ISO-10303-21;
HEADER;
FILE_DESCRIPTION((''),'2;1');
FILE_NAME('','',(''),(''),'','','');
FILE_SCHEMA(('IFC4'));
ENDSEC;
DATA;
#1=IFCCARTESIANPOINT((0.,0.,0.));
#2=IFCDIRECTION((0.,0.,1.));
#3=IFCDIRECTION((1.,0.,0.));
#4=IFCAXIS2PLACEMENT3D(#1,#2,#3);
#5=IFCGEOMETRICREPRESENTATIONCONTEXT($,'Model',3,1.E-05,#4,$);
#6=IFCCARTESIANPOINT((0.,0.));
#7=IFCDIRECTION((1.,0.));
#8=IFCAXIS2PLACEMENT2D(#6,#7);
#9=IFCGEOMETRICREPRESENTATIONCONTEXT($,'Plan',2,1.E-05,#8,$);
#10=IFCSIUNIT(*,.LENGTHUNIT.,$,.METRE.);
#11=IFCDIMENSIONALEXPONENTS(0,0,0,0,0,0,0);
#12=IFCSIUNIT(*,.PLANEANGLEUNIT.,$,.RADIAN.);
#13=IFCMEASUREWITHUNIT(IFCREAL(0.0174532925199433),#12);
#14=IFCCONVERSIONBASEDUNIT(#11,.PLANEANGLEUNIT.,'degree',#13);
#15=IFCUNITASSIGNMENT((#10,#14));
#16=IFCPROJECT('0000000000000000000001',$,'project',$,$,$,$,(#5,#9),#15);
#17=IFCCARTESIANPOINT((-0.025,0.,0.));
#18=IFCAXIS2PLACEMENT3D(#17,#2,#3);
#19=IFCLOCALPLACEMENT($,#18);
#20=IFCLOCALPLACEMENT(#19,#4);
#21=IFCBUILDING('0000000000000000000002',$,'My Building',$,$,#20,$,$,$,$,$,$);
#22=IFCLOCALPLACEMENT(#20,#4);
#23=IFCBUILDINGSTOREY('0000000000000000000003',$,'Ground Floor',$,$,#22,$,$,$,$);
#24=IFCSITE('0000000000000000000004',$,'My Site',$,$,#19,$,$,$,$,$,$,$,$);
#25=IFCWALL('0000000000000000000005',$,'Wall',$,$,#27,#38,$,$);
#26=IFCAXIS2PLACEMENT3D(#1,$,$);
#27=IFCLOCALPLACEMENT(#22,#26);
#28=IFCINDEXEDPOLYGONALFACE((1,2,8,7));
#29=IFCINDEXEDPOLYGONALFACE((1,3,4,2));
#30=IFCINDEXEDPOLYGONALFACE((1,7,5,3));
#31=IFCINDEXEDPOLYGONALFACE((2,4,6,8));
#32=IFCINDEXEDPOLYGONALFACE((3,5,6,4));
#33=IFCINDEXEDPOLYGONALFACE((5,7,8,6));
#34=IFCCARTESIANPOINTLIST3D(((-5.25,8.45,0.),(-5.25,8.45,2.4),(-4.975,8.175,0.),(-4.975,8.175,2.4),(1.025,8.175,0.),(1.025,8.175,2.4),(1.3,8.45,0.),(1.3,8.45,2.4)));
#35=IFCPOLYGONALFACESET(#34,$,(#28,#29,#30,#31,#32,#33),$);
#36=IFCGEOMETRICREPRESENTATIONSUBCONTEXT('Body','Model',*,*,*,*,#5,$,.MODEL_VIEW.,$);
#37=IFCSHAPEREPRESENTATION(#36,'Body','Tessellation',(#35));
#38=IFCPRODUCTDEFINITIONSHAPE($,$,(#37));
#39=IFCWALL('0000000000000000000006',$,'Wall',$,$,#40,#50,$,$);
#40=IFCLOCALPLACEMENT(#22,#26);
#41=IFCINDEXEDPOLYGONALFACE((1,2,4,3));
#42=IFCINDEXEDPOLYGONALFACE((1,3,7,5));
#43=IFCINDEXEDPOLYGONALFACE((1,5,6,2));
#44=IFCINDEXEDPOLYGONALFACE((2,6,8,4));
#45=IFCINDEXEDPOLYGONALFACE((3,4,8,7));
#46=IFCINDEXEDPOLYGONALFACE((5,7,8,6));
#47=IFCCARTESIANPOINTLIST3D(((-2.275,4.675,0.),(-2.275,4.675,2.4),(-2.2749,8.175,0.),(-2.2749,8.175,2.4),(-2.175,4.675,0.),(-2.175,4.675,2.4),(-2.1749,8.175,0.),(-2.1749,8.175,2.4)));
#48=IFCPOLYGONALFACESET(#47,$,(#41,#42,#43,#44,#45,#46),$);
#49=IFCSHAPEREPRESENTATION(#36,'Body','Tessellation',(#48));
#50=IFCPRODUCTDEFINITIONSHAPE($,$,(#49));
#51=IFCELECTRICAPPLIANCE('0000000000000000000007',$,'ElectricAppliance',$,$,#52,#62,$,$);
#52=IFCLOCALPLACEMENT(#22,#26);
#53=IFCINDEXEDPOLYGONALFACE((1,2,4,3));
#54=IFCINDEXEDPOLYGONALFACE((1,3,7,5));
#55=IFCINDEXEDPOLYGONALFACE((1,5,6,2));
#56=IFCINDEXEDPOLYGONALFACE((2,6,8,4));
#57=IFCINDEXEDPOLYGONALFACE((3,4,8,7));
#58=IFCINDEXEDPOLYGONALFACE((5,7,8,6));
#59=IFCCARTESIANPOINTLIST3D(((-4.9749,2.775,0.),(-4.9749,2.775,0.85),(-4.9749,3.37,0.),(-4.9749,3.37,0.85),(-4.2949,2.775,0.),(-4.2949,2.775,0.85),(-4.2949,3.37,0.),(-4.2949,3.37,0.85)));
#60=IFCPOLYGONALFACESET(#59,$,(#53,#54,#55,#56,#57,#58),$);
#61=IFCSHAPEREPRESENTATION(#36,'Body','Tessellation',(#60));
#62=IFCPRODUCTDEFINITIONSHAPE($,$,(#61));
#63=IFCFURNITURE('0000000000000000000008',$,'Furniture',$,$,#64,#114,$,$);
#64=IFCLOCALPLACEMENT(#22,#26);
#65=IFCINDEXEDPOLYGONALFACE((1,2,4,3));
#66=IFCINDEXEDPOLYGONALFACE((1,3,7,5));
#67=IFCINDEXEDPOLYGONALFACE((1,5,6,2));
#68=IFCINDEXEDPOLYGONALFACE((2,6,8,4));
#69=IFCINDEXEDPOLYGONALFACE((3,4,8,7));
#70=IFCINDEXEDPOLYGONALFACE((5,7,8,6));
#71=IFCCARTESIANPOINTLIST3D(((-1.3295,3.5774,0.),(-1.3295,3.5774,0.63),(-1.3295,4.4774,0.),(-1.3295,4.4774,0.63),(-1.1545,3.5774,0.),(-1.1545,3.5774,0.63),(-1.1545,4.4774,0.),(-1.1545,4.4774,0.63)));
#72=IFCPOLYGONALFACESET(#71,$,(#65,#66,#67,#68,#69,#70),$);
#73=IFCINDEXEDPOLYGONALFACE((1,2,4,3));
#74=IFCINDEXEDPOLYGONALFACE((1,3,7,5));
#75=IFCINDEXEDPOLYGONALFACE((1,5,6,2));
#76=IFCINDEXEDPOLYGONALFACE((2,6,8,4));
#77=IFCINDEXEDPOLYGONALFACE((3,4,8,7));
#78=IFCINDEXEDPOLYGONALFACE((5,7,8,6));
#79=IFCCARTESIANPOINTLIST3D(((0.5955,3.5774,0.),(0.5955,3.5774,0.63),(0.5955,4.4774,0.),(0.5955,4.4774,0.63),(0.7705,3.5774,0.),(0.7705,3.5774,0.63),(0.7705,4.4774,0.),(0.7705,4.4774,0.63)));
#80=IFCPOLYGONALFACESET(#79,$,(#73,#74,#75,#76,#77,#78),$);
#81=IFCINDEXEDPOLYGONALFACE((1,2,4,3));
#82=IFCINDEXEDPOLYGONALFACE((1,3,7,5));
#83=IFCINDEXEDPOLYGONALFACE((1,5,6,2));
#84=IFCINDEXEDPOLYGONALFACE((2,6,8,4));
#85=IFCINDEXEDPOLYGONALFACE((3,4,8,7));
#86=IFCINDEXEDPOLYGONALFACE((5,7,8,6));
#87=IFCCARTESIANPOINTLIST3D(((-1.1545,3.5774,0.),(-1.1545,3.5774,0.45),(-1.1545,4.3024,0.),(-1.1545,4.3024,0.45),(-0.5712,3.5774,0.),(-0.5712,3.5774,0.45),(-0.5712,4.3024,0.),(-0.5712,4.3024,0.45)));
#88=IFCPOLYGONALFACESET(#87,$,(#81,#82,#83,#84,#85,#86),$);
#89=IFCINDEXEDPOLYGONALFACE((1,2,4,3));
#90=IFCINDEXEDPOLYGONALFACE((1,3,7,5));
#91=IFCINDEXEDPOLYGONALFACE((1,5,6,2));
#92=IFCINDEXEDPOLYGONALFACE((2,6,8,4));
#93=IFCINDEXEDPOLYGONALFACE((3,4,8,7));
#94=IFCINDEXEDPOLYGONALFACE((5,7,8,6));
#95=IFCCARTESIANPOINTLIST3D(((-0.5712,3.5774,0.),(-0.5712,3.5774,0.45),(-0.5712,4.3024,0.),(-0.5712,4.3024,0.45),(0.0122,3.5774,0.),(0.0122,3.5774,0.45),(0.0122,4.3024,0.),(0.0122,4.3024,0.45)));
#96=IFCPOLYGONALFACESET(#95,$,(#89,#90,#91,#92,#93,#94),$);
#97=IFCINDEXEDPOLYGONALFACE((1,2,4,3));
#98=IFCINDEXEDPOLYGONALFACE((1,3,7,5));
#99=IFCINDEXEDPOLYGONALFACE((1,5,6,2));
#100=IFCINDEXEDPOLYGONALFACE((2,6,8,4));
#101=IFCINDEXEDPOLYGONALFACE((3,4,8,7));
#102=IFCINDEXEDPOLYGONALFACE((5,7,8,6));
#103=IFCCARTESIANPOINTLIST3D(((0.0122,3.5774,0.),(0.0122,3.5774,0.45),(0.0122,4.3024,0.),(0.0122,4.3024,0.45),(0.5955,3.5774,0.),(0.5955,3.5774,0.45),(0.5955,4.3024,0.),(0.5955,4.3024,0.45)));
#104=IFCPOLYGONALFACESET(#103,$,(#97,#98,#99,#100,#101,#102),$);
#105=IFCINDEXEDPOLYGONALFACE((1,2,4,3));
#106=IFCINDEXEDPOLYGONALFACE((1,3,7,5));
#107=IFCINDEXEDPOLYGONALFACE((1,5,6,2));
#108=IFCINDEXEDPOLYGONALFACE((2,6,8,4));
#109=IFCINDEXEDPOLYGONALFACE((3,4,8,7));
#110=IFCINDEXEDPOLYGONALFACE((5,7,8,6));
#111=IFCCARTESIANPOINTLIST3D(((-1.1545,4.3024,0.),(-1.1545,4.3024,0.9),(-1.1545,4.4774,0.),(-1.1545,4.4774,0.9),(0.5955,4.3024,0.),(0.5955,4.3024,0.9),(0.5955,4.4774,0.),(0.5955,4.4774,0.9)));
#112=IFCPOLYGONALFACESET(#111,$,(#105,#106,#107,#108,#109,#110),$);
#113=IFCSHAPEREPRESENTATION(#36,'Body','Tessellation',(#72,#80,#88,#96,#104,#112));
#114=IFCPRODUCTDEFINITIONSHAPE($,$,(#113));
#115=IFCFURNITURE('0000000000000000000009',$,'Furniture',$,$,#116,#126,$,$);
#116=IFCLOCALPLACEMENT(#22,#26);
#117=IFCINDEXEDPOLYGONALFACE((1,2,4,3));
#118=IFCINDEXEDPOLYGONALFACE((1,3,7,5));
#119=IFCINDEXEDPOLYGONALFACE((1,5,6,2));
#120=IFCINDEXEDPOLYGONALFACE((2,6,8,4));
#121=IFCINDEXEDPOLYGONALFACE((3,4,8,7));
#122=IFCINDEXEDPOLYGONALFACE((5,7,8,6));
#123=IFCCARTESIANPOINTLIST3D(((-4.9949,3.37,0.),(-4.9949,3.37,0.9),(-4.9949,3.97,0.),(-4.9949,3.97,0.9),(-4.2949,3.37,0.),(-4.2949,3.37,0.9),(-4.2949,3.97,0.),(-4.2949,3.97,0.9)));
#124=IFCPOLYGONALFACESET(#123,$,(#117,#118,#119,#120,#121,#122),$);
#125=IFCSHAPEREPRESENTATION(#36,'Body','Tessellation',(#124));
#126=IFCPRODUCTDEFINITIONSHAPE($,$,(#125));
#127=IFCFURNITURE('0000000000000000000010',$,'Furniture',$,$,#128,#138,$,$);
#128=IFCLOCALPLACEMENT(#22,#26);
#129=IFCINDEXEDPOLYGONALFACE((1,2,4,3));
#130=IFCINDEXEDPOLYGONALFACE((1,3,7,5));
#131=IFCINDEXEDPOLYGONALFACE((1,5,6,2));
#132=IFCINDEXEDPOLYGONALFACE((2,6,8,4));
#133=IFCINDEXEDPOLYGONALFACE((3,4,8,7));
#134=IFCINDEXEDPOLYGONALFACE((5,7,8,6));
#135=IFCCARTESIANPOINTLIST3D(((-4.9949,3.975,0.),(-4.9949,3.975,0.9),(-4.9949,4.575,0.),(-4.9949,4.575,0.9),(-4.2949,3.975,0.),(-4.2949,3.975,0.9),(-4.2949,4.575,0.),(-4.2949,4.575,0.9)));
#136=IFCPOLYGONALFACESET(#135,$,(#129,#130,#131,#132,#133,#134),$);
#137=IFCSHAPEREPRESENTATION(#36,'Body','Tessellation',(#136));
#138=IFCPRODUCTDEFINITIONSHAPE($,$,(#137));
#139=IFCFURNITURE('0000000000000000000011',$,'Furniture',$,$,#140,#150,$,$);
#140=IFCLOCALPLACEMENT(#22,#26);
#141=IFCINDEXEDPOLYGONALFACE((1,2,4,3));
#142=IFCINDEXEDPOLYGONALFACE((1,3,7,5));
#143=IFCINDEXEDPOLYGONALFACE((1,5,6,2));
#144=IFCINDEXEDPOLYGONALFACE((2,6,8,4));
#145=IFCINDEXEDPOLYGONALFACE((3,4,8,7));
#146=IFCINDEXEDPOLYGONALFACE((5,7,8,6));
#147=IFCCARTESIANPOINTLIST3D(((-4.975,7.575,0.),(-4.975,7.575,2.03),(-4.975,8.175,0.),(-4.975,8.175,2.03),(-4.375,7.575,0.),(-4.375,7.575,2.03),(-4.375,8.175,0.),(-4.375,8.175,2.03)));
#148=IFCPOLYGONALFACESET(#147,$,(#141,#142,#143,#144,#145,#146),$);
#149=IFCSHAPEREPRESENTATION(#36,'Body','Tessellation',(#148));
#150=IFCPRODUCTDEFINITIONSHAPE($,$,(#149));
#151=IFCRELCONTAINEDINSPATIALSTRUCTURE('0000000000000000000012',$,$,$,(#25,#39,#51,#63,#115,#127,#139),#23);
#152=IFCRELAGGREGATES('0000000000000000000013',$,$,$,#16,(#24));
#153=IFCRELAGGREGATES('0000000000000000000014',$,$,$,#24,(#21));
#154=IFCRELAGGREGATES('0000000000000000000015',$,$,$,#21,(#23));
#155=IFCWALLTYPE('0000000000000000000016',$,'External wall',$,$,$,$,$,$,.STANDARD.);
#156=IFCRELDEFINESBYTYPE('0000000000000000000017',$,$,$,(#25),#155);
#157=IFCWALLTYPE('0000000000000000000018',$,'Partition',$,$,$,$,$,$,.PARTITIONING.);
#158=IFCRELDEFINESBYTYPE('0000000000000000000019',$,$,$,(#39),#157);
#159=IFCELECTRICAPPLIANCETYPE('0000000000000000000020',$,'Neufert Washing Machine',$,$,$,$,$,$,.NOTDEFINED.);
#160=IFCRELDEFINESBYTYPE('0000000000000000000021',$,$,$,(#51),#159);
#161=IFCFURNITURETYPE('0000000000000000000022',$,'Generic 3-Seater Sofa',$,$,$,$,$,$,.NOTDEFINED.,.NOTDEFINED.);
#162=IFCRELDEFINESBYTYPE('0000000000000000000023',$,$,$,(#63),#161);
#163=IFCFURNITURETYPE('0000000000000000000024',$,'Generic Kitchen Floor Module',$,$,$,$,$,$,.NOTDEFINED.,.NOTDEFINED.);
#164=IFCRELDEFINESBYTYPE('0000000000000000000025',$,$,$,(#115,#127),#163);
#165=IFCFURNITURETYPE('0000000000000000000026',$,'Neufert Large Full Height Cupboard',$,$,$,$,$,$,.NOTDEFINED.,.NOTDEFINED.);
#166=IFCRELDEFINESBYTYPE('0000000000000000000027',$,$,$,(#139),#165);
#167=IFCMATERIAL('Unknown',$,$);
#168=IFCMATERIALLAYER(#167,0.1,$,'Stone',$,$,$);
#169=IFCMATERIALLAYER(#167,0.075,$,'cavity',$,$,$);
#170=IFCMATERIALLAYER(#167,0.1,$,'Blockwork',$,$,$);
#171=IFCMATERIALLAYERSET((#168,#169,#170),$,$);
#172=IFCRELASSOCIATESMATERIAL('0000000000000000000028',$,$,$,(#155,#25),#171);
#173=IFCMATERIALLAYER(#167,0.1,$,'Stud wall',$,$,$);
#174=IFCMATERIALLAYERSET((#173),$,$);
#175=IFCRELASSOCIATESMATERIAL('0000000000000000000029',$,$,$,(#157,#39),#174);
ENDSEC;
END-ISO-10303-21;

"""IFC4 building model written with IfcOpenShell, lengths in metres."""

from ifc_helpers import new_model, entity, si_unit, converted_unit, frame, origin_with_axes, origin_2d_with_axis, place, context, subcontext, project, spatial, line, indexed_curve, outline, extrude, clip, halfspace, shape, source, transform, mapped, material, layer, layer_set, layer_usage, type_object, type_shapes, element, save


model = new_model("IFC4")

# Units and contexts
model_context = context("Model", 3, precision=1e-05, world=origin_with_axes())
plan_context = context("Plan", 2, precision=1e-05, world=origin_2d_with_axis())
body_context_1 = subcontext(model_context, "Body", "Model", "MODEL_VIEW")
body_context_2 = subcontext(plan_context, "Body", "Plan", "PLAN_VIEW")
ifc_project = project(units=[si_unit("LENGTHUNIT", "METRE"), converted_unit("PLANEANGLEUNIT", "degree", entity("IfcReal", 0.0174532925199433), si_unit("PLANEANGLEUNIT", "RADIAN"), dimensions=[0, 0, 0, 0, 0, 0, 0])], contexts=[model_context, plan_context])

# Site, building, storey
site_placement = place(None, frame((-0.025, 0.0, 0.0), z_axis=(0.0, 0.0, 1.0), x_axis=(1.0, 0.0, 0.0)))
site = spatial("IfcSite", under=ifc_project, at=site_placement, Name="My Site")
building_placement = place(site_placement, origin_with_axes())
building = spatial("IfcBuilding", under=site, at=building_placement, Name="My Building")
storey_placement = place(building_placement, frame((0.0, 0.0, 0.0), z_axis=(0.0, 0.0, 1.0), x_axis=(1.0, 0.0, 0.0)))
storey = spatial("IfcBuildingStorey", under=building, at=storey_placement, Name="Ground Floor")

# Wall
ifc_material = material(Name="Unknown")
ifc_layer_1 = layer(ifc_material, 0.1, Name="Stone")
ifc_layer_2 = layer(ifc_material, 0.075, Name="cavity")
ifc_layer_3 = layer(ifc_material, 0.1, Name="Blockwork")
ifc_layer_set_1 = layer_set([ifc_layer_1, ifc_layer_2, ifc_layer_3])
ifc_layer_usage_1 = layer_usage(ifc_layer_set_1, "AXIS2", "POSITIVE", 0.0)
wall_type_1 = type_object("IfcWallType", Name="External wall", PredefinedType="STANDARD", material=ifc_layer_set_1)
wall_1_placement = place(storey_placement, frame((1.3, 8.45, 0.0), z_axis=(0.0, 0.0, 1.0), x_axis=(-1.0, 0.0, 0.0)))
element("IfcWall", 1, at=wall_1_placement, inside=storey, type_object=wall_type_1, material=ifc_layer_usage_1, Name="Wall", context=body_context_1, shape_type="Clipping", body=[
    clip(clip(extrude(outline(indexed_curve([(0.0, 0.0), (0.0, 0.275), (6.55, 0.275), (6.55, 0.0), (0.0, 0.0)], self_intersect=False)), origin_with_axes(), (0.0, 0.0, 1.0), 2.4), halfspace(frame((6.55, 0.0, 0.0), z_axis=(0.707106, 0.707107, 0.0), x_axis=(-0.707107, 0.707106, 0.0)), False)), halfspace(frame((0.0, 0.0, 0.0), z_axis=(-0.707106, 0.707107, 0.0), x_axis=(0.707107, 0.707106, 0.0)), False)),
])

# Shared definitions
ifc_layer_4 = layer(ifc_material, 0.1, Name="Stud wall")
ifc_layer_set_2 = layer_set([ifc_layer_4])
wall_type_2 = type_object("IfcWallType", Name="Partition", PredefinedType="PARTITIONING", material=ifc_layer_set_2)

# Wall
ifc_layer_usage_2 = layer_usage(ifc_layer_set_2, "AXIS2", "POSITIVE", 0.0)
wall_2_placement = place(storey_placement, frame((-2.175, 4.675, 0.0), z_axis=(0.0, 0.0, 1.0), x_axis=(0.0, 1.0, 0.0)))
element("IfcWall", 2, at=wall_2_placement, inside=storey, type_object=wall_type_2, material=ifc_layer_usage_2, Name="Wall", context=body_context_1, shape_type="SweptSolid", body=[
    extrude(outline(indexed_curve([(0.0, 0.0), (0.0, 0.1), (3.5, 0.1), (3.5, 0.0), (0.0, 0.0)], self_intersect=False)), origin_with_axes(), (0.0, 0.0, 1.0), 2.4),
])

# Electric appliance
electric_appliance_type_1 = type_object("IfcElectricApplianceType", Name="Neufert Washing Machine", PredefinedType="NOTDEFINED")
shared_shape_1 = source(origin_with_axes(), body_context_1, "Body", "SweptSolid", [
    extrude(outline(indexed_curve([(0.0, 0.0), (0.595, 0.0), (0.595, 0.68), (0.0, 0.68)], segments=[line(1, 2, 3, 4, 1)])), origin_with_axes(), (0.0, 0.0, 1.0), 0.85),
])
shared_shape_2 = source(origin_with_axes(), body_context_2, "Body", "Curve2D", [
    entity("IfcIndexedPolyCurve", entity("IfcCartesianPointList2D", [[0.0, 0.0], [0.595, 0.0], [0.595, 0.68], [0.0, 0.68]]), [entity("IfcLineIndex", [1, 2, 3, 4, 1])]),
    entity("IfcCircle", entity("IfcAxis2Placement2D", entity("IfcCartesianPoint", [0.2975, 0.34])), 0.1785),
    entity("IfcCircle", entity("IfcAxis2Placement2D", entity("IfcCartesianPoint", [0.2975, 0.34])), 0.0595),
])
type_shapes(electric_appliance_type_1, [shared_shape_1, shared_shape_2])
electric_appliance_1_placement = place(storey_placement, frame((-4.2949, 2.775, 0.0), z_axis=(0.0, 0.0, 1.0), x_axis=(0.0, 1.0, 0.0)))
element("IfcElectricAppliance", 3, at=electric_appliance_1_placement, inside=storey, type_object=electric_appliance_type_1, Name="ElectricAppliance", shapes=[
    shape(body_context_1, "Body", "MappedRepresentation", [mapped(shared_shape_1, transform((0.0, 0.0, 0.0), x_axis=(1.0, 0.0, 0.0), y_axis=(0.0, 1.0, 0.0), z_axis=(0.0, 0.0, 1.0), scale=1.0))]),
    shape(body_context_2, "Body", "MappedRepresentation", [mapped(shared_shape_2, transform((0.0, 0.0, 0.0), x_axis=(1.0, 0.0, 0.0), y_axis=(0.0, 1.0, 0.0), z_axis=(0.0, 0.0, 1.0), scale=1.0))]),
])

# Furniture
furniture_type_1 = type_object("IfcFurnitureType", Name="Generic 3-Seater Sofa", AssemblyPlace="NOTDEFINED", PredefinedType="NOTDEFINED")
shared_shape_3 = source(origin_with_axes(), body_context_1, "Body", "SweptSolid", [
    extrude(outline(indexed_curve([(0.0, 0.0), (0.175, 0.0), (0.175, 0.9), (0.0, 0.9)], segments=[line(1, 2, 3, 4, 1)])), frame((-1.05, -0.9, 0.0), z_axis=(0.0, 0.0, 1.0), x_axis=(1.0, 0.0, 0.0)), (0.0, 0.0, 1.0), 0.63),
    extrude(outline(indexed_curve([(0.0, 0.0), (0.175, 0.0), (0.175, 0.9), (0.0, 0.9)], segments=[line(1, 2, 3, 4, 1)])), frame((0.875, -0.9, 0.0), z_axis=(0.0, 0.0, 1.0), x_axis=(1.0, 0.0, 0.0)), (0.0, 0.0, 1.0), 0.63),
    extrude(outline(indexed_curve([(0.175, 0.0), (0.7583, 0.0), (0.7583, 0.725), (0.175, 0.725)], segments=[line(1, 2, 3, 4, 1)])), frame((-1.05, -0.9, 0.0), z_axis=(0.0, 0.0, 1.0), x_axis=(1.0, 0.0, 0.0)), (0.0, 0.0, 1.0), 0.45),
    extrude(outline(indexed_curve([(0.7583, 0.0), (1.3417, 0.0), (1.3417, 0.725), (0.7583, 0.725)], segments=[line(1, 2, 3, 4, 1)])), frame((-1.05, -0.9, 0.0), z_axis=(0.0, 0.0, 1.0), x_axis=(1.0, 0.0, 0.0)), (0.0, 0.0, 1.0), 0.45),
    extrude(outline(indexed_curve([(1.3417, 0.0), (1.925, 0.0), (1.925, 0.725), (1.3417, 0.725)], segments=[line(1, 2, 3, 4, 1)])), frame((-1.05, -0.9, 0.0), z_axis=(0.0, 0.0, 1.0), x_axis=(1.0, 0.0, 0.0)), (0.0, 0.0, 1.0), 0.45),
    extrude(outline(indexed_curve([(0.175, 0.725), (1.925, 0.725), (1.925, 0.9), (0.175, 0.9)], segments=[line(1, 2, 3, 4, 1)])), frame((-1.05, -0.9, 0.0), z_axis=(0.0, 0.0, 1.0), x_axis=(1.0, 0.0, 0.0)), (0.0, 0.0, 1.0), 0.9),
])
shared_shape_4 = source(origin_with_axes(), body_context_2, "Body", "Curve2D", [
    entity("IfcIndexedPolyCurve", entity("IfcCartesianPointList2D", [[-1.05, -0.9], [-0.875, -0.9], [-0.875, 0.0], [-1.05, 0.0]]), [entity("IfcLineIndex", [1, 2, 3, 4, 1])]),
    entity("IfcIndexedPolyCurve", entity("IfcCartesianPointList2D", [[0.875, -0.9], [1.05, -0.9], [1.05, 0.0], [0.875, 0.0]]), [entity("IfcLineIndex", [1, 2, 3, 4, 1])]),
    entity("IfcIndexedPolyCurve", entity("IfcCartesianPointList2D", [[-0.875, -0.9], [-0.2917, -0.9], [-0.2917, -0.175], [-0.875, -0.175]]), [entity("IfcLineIndex", [1, 2, 3, 4, 1])]),
    entity("IfcIndexedPolyCurve", entity("IfcCartesianPointList2D", [[-0.2917, -0.9], [0.2917, -0.9], [0.2917, -0.175], [-0.2917, -0.175]]), [entity("IfcLineIndex", [1, 2, 3, 4, 1])]),
    entity("IfcIndexedPolyCurve", entity("IfcCartesianPointList2D", [[0.2917, -0.9], [0.875, -0.9], [0.875, -0.175], [0.2917, -0.175]]), [entity("IfcLineIndex", [1, 2, 3, 4, 1])]),
    entity("IfcIndexedPolyCurve", entity("IfcCartesianPointList2D", [[-0.875, -0.175], [0.875, -0.175], [0.875, 0.0], [-0.875, 0.0]]), [entity("IfcLineIndex", [1, 2, 3, 4, 1])]),
])
type_shapes(furniture_type_1, [shared_shape_3, shared_shape_4])
furniture_1_placement = place(storey_placement, frame((-0.2795, 4.4774, 0.0), z_axis=(0.0, 0.0, 1.0), x_axis=(1.0, 0.0, 0.0)))
element("IfcFurniture", 4, at=furniture_1_placement, inside=storey, type_object=furniture_type_1, Name="Furniture", shapes=[
    shape(body_context_1, "Body", "MappedRepresentation", [mapped(shared_shape_3, transform((0.0, 0.0, 0.0), x_axis=(1.0, 0.0, 0.0), y_axis=(0.0, 1.0, 0.0), z_axis=(0.0, 0.0, 1.0), scale=1.0))]),
    shape(body_context_2, "Body", "MappedRepresentation", [mapped(shared_shape_4, transform((0.0, 0.0, 0.0), x_axis=(1.0, 0.0, 0.0), y_axis=(0.0, 1.0, 0.0), z_axis=(0.0, 0.0, 1.0), scale=1.0))]),
])
furniture_type_2 = type_object("IfcFurnitureType", Name="Generic Kitchen Floor Module", AssemblyPlace="NOTDEFINED", PredefinedType="NOTDEFINED")
shared_shape_5 = source(origin_with_axes(), body_context_1, "Body", "SweptSolid", [
    extrude(outline(indexed_curve([(0.0, 0.0), (0.6, 0.0), (0.6, 0.7), (0.0, 0.7)], segments=[line(1, 2, 3, 4, 1)])), origin_with_axes(), (0.0, 0.0, 1.0), 0.9),
])
shared_shape_6 = source(origin_with_axes(), body_context_2, "Body", "Curve2D", [
    entity("IfcIndexedPolyCurve", entity("IfcCartesianPointList2D", [[0.0, 0.0], [0.6, 0.0], [0.6, 0.7], [0.0, 0.7]]), [entity("IfcLineIndex", [1, 2, 3, 4, 1])]),
])
type_shapes(furniture_type_2, [shared_shape_5, shared_shape_6])
for number, where, z_axis, x_axis, name in (
    (5, (-4.2949, 3.37, 0.0), (0.0, 0.0, 1.0), (0.0, 1.0, 0.0), "Furniture"),
    (6, (-4.2949, 3.975, 0.0), (0.0, 0.0, 1.0), (0.0, 1.0, 0.0), "Furniture"),
):
    element("IfcFurniture", number, at=place(storey_placement, frame(where, z_axis=z_axis, x_axis=x_axis)), inside=storey, type_object=furniture_type_2, Name=name, shapes=[
        shape(body_context_1, "Body", "MappedRepresentation", [mapped(shared_shape_5, transform((0.0, 0.0, 0.0), x_axis=(1.0, 0.0, 0.0), y_axis=(0.0, 1.0, 0.0), z_axis=(0.0, 0.0, 1.0), scale=1.0))]),
        shape(body_context_2, "Body", "MappedRepresentation", [mapped(shared_shape_6, transform((0.0, 0.0, 0.0), x_axis=(1.0, 0.0, 0.0), y_axis=(0.0, 1.0, 0.0), z_axis=(0.0, 0.0, 1.0), scale=1.0))]),
    ])
furniture_type_3 = type_object("IfcFurnitureType", Name="Neufert Large Full Height Cupboard", AssemblyPlace="NOTDEFINED", PredefinedType="NOTDEFINED")
shared_shape_7 = source(origin_with_axes(), body_context_1, "Body", "SweptSolid", [
    extrude(outline(indexed_curve([(0.0, 0.0), (0.6, 0.0), (0.6, 0.6), (0.0, 0.6)], segments=[line(1, 2, 3, 4, 1)])), origin_with_axes(), (0.0, 0.0, 1.0), 2.03),
])
shared_shape_8 = source(origin_with_axes(), body_context_2, "Body", "Curve2D", [
    entity("IfcIndexedPolyCurve", entity("IfcCartesianPointList2D", [[0.0, 0.0], [0.6, 0.0], [0.6, 0.6], [0.0, 0.6]]), [entity("IfcLineIndex", [1, 2, 3, 4, 1])]),
])
type_shapes(furniture_type_3, [shared_shape_7, shared_shape_8])
furniture_2_placement = place(storey_placement, frame((-4.975, 7.575, 0.0), z_axis=(0.0, 0.0, 1.0), x_axis=(1.0, 0.0, 0.0)))
element("IfcFurniture", 7, at=furniture_2_placement, inside=storey, type_object=furniture_type_3, Name="Furniture", shapes=[
    shape(body_context_1, "Body", "MappedRepresentation", [mapped(shared_shape_7, transform((0.0, 0.0, 0.0), x_axis=(1.0, 0.0, 0.0), y_axis=(0.0, 1.0, 0.0), z_axis=(0.0, 0.0, 1.0), scale=1.0))]),
    shape(body_context_2, "Body", "MappedRepresentation", [mapped(shared_shape_8, transform((0.0, 0.0, 0.0), x_axis=(1.0, 0.0, 0.0), y_axis=(0.0, 1.0, 0.0), z_axis=(0.0, 0.0, 1.0), scale=1.0))]),
])

save(model, "model.ifc")
